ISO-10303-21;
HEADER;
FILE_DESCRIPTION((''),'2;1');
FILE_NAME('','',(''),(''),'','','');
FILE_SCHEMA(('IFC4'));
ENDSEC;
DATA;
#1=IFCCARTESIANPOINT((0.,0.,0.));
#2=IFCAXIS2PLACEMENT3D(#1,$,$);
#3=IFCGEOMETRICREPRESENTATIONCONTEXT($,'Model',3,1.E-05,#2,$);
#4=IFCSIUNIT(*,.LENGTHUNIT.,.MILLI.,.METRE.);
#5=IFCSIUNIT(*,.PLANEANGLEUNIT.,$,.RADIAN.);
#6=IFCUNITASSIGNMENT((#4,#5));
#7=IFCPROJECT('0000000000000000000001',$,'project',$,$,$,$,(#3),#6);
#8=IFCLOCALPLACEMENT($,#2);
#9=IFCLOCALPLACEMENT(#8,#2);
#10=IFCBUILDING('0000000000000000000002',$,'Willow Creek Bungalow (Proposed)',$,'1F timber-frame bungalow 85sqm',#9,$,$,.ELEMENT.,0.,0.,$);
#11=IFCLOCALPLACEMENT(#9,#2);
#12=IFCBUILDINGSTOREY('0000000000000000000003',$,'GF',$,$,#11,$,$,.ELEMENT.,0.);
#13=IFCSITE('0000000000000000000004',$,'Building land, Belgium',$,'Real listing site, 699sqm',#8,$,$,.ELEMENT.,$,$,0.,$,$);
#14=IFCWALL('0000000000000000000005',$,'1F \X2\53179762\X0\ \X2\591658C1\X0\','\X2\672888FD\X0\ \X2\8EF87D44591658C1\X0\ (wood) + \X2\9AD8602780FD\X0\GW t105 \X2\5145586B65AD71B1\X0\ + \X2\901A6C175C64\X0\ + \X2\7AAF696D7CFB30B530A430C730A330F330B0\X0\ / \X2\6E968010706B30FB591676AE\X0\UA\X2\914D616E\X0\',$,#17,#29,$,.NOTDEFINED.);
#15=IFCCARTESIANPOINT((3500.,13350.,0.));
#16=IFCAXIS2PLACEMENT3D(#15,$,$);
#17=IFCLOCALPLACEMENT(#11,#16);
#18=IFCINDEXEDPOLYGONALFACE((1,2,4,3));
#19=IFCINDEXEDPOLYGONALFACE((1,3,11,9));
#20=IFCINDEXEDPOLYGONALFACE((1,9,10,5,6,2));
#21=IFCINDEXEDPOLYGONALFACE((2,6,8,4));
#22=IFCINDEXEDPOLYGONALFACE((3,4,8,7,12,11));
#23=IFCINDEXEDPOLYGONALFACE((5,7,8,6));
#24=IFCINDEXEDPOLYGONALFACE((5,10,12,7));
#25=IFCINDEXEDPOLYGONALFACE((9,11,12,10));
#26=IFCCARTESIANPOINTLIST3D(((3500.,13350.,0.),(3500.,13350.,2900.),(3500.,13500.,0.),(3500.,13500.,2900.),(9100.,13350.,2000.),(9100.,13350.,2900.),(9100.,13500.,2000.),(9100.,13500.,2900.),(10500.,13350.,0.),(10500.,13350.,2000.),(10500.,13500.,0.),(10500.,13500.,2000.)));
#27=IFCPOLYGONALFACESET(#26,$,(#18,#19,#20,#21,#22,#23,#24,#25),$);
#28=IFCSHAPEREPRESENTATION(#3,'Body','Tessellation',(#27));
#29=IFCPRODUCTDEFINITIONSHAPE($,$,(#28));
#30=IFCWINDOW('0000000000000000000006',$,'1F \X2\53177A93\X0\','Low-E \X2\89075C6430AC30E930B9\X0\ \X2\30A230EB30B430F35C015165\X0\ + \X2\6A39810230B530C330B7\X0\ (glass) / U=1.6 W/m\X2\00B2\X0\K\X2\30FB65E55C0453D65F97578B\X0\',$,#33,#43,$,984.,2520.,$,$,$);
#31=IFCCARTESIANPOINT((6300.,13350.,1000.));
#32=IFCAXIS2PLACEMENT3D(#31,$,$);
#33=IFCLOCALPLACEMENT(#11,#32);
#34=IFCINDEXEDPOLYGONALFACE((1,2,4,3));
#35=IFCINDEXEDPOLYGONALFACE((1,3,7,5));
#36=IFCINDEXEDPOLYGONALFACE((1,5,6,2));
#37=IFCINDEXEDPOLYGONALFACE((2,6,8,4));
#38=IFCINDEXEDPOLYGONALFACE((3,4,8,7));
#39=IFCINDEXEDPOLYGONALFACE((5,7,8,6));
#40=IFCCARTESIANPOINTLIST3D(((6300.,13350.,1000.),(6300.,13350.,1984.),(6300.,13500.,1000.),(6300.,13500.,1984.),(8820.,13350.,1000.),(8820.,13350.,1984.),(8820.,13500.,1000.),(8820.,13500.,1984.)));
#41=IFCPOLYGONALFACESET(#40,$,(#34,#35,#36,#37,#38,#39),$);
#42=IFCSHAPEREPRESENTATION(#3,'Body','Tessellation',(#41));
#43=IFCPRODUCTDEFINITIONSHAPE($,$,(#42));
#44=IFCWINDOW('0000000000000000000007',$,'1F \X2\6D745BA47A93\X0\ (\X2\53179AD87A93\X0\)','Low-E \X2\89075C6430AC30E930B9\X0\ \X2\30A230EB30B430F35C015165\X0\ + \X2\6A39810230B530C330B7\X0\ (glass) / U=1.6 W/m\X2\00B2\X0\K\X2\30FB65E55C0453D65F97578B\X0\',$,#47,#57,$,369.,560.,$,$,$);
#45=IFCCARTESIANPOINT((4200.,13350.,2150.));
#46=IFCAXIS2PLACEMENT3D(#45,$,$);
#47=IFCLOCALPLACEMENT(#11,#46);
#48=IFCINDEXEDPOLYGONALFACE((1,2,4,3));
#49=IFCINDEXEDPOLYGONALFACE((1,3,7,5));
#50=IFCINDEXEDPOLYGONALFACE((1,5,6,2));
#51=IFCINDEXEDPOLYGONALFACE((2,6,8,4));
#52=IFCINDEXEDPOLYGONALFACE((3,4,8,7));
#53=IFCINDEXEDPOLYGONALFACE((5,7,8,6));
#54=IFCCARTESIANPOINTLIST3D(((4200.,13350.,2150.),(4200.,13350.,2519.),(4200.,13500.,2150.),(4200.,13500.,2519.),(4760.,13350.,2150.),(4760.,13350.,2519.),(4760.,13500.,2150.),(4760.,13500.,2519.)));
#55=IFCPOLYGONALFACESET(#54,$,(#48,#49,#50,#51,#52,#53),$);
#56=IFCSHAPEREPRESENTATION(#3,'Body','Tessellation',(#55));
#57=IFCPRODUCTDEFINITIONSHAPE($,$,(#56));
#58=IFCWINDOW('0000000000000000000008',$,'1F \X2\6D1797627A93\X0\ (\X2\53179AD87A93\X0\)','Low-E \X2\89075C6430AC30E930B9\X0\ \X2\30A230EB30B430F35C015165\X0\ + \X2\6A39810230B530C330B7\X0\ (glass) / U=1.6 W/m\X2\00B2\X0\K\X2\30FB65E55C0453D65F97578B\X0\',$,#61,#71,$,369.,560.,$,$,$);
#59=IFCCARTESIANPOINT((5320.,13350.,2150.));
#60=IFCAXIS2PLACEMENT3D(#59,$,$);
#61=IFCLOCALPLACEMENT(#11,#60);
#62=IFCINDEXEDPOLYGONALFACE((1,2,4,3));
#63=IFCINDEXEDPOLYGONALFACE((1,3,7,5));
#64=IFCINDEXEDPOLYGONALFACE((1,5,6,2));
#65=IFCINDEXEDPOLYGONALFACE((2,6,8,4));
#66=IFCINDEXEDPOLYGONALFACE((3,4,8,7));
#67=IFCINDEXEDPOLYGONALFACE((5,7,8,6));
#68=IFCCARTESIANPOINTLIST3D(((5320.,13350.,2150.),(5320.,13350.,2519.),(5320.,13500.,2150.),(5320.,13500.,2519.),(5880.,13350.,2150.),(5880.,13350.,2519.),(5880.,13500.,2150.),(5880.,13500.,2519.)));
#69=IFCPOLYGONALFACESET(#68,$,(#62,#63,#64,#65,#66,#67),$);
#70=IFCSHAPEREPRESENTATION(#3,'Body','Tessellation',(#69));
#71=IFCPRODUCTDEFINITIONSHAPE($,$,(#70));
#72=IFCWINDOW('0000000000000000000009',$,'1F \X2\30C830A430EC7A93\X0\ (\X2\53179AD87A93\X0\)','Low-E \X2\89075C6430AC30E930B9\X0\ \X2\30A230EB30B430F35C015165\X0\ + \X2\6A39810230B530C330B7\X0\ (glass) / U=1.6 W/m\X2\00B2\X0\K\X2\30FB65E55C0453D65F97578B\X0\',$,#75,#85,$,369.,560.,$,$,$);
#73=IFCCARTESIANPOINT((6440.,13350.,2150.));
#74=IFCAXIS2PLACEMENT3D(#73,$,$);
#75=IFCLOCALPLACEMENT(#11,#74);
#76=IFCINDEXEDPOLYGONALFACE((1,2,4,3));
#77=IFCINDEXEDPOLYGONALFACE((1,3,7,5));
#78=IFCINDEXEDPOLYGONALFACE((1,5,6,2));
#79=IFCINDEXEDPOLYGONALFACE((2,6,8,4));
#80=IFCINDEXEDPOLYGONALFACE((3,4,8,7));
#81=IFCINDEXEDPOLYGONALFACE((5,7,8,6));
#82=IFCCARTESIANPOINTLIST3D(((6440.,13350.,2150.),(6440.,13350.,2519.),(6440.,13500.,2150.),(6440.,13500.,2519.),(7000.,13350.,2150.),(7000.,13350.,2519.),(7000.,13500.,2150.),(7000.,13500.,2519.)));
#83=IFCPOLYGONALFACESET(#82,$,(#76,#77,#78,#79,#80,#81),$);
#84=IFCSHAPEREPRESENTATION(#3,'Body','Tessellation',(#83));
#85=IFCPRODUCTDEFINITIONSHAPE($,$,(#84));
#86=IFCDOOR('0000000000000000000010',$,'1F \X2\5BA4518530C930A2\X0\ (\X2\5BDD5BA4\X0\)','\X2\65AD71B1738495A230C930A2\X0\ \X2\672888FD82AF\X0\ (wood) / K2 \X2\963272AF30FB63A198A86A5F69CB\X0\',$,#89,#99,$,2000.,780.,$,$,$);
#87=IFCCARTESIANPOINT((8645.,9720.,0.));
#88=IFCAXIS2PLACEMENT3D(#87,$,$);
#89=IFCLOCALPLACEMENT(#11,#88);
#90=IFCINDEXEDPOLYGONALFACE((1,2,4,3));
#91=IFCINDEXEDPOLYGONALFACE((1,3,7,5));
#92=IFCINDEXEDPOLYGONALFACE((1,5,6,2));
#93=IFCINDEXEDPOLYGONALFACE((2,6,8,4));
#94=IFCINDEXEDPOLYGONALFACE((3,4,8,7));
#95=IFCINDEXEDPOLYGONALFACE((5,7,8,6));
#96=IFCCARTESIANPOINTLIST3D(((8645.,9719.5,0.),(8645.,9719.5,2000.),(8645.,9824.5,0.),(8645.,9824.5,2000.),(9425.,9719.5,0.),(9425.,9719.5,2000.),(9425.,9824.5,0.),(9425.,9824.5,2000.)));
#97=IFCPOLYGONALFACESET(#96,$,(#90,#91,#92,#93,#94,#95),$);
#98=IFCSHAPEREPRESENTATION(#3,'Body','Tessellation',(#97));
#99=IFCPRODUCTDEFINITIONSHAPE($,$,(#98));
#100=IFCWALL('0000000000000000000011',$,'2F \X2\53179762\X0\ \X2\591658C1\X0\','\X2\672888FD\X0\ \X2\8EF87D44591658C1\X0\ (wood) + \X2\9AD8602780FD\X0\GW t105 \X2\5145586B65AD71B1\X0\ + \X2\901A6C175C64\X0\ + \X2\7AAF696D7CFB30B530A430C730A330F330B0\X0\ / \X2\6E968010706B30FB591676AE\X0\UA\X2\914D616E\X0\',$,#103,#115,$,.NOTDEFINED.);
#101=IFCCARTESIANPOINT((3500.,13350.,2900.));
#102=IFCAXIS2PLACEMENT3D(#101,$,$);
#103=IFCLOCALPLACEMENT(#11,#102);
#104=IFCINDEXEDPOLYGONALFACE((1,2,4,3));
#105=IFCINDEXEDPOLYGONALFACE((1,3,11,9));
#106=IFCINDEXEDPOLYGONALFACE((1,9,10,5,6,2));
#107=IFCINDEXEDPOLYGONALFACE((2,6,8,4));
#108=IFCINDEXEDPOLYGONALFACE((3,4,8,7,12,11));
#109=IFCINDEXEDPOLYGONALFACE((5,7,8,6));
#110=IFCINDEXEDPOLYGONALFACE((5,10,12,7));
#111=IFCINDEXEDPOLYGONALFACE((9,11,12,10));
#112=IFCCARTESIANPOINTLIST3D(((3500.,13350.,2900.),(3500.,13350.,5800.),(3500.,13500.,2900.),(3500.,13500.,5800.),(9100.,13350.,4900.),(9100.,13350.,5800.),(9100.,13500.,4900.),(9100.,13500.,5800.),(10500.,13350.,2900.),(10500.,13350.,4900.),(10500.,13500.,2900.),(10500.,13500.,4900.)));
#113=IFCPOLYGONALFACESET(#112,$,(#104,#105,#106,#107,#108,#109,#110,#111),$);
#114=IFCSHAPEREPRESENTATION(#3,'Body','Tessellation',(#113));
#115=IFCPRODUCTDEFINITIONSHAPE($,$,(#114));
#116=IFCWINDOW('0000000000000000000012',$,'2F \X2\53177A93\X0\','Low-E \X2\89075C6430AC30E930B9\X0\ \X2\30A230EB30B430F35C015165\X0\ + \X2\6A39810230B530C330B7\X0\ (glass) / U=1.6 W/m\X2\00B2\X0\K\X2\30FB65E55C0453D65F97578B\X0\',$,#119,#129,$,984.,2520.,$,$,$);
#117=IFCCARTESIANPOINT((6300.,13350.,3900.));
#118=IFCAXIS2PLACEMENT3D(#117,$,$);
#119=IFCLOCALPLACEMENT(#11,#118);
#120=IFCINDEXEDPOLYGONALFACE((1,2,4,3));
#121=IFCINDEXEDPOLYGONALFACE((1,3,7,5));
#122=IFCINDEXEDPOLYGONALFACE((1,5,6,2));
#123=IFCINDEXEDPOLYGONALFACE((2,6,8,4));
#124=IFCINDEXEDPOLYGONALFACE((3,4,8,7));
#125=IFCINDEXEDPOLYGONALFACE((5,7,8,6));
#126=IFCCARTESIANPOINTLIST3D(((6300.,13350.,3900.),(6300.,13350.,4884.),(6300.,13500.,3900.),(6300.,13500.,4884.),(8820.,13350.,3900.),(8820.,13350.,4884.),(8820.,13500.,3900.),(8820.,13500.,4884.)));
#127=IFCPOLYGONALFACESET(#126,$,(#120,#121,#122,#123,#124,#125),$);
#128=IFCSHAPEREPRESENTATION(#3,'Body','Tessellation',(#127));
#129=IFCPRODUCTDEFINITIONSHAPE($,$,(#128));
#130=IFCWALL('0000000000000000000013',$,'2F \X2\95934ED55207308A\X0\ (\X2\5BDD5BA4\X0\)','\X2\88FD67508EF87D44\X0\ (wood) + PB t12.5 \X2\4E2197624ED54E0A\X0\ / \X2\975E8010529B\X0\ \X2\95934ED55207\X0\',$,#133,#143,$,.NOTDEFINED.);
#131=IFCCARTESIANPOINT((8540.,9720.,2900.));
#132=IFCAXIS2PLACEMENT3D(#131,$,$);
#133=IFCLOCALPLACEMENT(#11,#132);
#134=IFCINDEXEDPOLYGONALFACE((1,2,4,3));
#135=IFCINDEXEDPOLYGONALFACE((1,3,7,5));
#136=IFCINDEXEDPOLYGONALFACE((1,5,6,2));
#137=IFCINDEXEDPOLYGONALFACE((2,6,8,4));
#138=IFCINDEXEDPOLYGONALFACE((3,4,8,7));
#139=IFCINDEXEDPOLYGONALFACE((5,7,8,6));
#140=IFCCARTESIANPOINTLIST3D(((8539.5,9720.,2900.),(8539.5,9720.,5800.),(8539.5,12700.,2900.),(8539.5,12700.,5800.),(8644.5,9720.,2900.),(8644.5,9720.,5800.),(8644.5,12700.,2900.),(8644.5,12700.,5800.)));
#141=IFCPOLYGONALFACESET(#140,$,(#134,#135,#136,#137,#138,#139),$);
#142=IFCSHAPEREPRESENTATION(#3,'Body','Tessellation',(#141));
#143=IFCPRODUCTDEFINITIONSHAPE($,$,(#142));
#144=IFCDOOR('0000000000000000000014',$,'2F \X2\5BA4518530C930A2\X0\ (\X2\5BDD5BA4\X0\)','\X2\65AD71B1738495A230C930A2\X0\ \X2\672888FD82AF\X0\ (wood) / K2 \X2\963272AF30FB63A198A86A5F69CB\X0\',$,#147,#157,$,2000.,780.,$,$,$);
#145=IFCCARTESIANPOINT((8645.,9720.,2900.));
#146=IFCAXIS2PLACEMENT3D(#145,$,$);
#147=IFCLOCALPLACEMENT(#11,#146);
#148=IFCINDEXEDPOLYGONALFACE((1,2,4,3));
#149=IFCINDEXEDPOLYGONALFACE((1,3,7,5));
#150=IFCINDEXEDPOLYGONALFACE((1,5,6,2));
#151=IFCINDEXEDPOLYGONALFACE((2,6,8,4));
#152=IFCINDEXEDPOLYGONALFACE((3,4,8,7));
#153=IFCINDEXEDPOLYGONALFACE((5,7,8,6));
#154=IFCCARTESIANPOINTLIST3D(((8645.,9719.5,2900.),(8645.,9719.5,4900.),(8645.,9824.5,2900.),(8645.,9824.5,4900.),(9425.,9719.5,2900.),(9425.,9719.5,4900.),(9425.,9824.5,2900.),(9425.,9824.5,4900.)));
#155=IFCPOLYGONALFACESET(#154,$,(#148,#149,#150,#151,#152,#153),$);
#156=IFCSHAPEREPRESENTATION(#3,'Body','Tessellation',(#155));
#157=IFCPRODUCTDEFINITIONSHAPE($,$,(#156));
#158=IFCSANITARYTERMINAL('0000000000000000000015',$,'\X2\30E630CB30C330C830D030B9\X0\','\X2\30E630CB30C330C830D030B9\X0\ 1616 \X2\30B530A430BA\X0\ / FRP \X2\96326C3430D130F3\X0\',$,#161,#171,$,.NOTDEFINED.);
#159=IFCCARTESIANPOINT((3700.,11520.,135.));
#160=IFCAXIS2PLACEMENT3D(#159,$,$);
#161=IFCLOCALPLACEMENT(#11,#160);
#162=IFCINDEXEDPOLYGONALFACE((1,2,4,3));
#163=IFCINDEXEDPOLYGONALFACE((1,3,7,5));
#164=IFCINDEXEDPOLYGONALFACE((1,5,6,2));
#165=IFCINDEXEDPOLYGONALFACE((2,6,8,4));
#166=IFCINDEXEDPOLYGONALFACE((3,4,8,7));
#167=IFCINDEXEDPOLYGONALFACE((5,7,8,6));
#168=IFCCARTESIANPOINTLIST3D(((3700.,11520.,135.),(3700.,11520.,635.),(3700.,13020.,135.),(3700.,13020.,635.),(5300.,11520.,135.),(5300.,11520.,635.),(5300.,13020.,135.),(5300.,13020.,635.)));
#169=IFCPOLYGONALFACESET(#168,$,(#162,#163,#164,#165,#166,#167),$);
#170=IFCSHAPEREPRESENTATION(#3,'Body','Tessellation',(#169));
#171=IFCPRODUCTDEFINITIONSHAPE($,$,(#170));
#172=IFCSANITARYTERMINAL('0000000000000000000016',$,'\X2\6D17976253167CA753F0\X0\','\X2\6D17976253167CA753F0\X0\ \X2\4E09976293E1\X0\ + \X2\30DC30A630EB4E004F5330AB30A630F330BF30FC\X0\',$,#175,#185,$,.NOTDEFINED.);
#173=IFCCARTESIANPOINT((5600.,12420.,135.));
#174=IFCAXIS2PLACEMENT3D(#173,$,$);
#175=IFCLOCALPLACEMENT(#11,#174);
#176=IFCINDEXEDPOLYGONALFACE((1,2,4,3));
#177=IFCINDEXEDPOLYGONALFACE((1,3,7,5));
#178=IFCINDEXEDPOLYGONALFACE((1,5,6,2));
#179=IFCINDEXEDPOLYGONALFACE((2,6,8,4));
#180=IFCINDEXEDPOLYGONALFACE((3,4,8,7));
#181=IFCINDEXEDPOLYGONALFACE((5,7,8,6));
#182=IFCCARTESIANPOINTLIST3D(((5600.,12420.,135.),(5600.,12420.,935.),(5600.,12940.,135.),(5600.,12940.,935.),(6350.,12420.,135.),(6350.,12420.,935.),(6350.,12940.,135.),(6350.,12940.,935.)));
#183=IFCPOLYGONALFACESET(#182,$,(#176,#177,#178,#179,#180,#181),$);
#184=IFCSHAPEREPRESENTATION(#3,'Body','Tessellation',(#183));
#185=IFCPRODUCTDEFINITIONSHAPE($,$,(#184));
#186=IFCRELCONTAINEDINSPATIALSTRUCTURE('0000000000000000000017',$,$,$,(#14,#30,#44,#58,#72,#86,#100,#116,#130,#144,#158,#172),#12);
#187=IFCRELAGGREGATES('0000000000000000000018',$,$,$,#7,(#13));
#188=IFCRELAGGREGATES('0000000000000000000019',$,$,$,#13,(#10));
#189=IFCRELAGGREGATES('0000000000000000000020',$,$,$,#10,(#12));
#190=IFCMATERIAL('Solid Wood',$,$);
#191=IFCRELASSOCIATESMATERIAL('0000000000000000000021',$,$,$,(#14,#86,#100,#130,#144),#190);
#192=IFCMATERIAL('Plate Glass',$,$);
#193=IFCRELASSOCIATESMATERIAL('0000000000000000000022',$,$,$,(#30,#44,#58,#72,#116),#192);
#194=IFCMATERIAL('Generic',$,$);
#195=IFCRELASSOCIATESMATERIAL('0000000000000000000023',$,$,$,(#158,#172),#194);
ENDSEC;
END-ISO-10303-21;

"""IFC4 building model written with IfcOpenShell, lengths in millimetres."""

from ifc_helpers import new_model, si_unit, frame, frame_2d, origin, place, context, project, spatial, rectangle, extrude, material, element, fill, save


model = new_model("IFC4")

# Units and contexts
model_context = context("Model", 3, precision=1e-05, world=origin())
ifc_project = project(units=[si_unit("LENGTHUNIT", "METRE", prefix="MILLI"), si_unit("PLANEANGLEUNIT", "RADIAN")], contexts=[model_context])

# Site, building, storey
site_placement = place(None, origin())
site = spatial("IfcSite", under=ifc_project, at=site_placement, Name="Building land, Belgium", ObjectType="Real listing site, 699sqm", CompositionType="ELEMENT", RefElevation=0.0)
building_placement = place(site_placement, origin())
building = spatial("IfcBuilding", under=site, at=building_placement, Name="Willow Creek Bungalow (Proposed)", ObjectType="1F timber-frame bungalow 85sqm", CompositionType="ELEMENT", ElevationOfRefHeight=0.0, ElevationOfTerrain=0.0)
storey_placement = place(building_placement, origin())
storey = spatial("IfcBuildingStorey", under=building, at=storey_placement, Name="GF", CompositionType="ELEMENT", Elevation=0.0)

# Wall, openings, windows
ifc_material_1 = material(Name="Solid Wood")
wall_1_placement = place(storey_placement, frame((3500.0, 13350.0, 0.0)))
wall_1 = element("IfcWall", 1, at=wall_1_placement, inside=storey, material=ifc_material_1, Name="1F 北面 外壁", Description="木製 軸組外壁 (wood) + 高性能GW t105 充填断熱 + 通気層 + 窯業系サイディング / 準耐火・外皮UA配慮", PredefinedType="NOTDEFINED", context=model_context, shape_type="SweptSolid", body=[
    extrude(rectangle(XDim=7000.0, YDim=150.0, at=frame_2d((3500.0, 75.0))), frame((3500.0, 13350.0, 0.0)), (0.0, 0.0, 1.0), 2900.0),
])
opening_1_placement = place(storey_placement, frame((6300.0, 13350.0, 1000.0)))
opening_1 = element("IfcOpeningElement", 2, at=opening_1_placement, cuts=wall_1, PredefinedType="NOTDEFINED", context=model_context, shape_type="SweptSolid", body=[
    extrude(rectangle(XDim=2520.0, YDim=150.0, at=frame_2d((1260.0, 75.0))), frame((6300.0, 13350.0, 1000.0)), (0.0, 0.0, 1.0), 984.0),
])
opening_2_placement = place(storey_placement, frame((4200.0, 13350.0, 2150.0)))
opening_2 = element("IfcOpeningElement", 3, at=opening_2_placement, cuts=wall_1, PredefinedType="NOTDEFINED", context=model_context, shape_type="SweptSolid", body=[
    extrude(rectangle(XDim=560.0, YDim=150.0, at=frame_2d((280.0, 75.0))), frame((4200.0, 13350.0, 2150.0)), (0.0, 0.0, 1.0), 369.0),
])
opening_3_placement = place(storey_placement, frame((5320.0, 13350.0, 2150.0)))
opening_3 = element("IfcOpeningElement", 4, at=opening_3_placement, cuts=wall_1, PredefinedType="NOTDEFINED", context=model_context, shape_type="SweptSolid", body=[
    extrude(rectangle(XDim=560.0, YDim=150.0, at=frame_2d((280.0, 75.0))), frame((5320.0, 13350.0, 2150.0)), (0.0, 0.0, 1.0), 369.0),
])
opening_4_placement = place(storey_placement, frame((6440.0, 13350.0, 2150.0)))
opening_4 = element("IfcOpeningElement", 5, at=opening_4_placement, cuts=wall_1, PredefinedType="NOTDEFINED", context=model_context, shape_type="SweptSolid", body=[
    extrude(rectangle(XDim=560.0, YDim=150.0, at=frame_2d((280.0, 75.0))), frame((6440.0, 13350.0, 2150.0)), (0.0, 0.0, 1.0), 369.0),
])
ifc_material_2 = material(Name="Plate Glass")
window_1_placement = place(storey_placement, frame((6300.0, 13350.0, 1000.0)))
window_1 = element("IfcWindow", 6, at=window_1_placement, inside=storey, material=ifc_material_2, Name="1F 北窓", Description="Low-E 複層ガラス アルゴン封入 + 樹脂サッシ (glass) / U=1.6 W/m²K・日射取得型", OverallHeight=984.0, OverallWidth=2520.0, context=model_context, shape_type="SweptSolid", body=[
    extrude(rectangle(XDim=2520.0, YDim=150.0, at=frame_2d((1260.0, 75.0))), frame((6300.0, 13350.0, 1000.0)), (0.0, 0.0, 1.0), 984.0),
])
fill(opening_1, window_1)
window_2_placement = place(storey_placement, frame((4200.0, 13350.0, 2150.0)))
window_2 = element("IfcWindow", 7, at=window_2_placement, inside=storey, material=ifc_material_2, Name="1F 浴室窓 (北高窓)", Description="Low-E 複層ガラス アルゴン封入 + 樹脂サッシ (glass) / U=1.6 W/m²K・日射取得型", OverallHeight=369.0, OverallWidth=560.0, context=model_context, shape_type="SweptSolid", body=[
    extrude(rectangle(XDim=560.0, YDim=150.0, at=frame_2d((280.0, 75.0))), frame((4200.0, 13350.0, 2150.0)), (0.0, 0.0, 1.0), 369.0),
])
fill(opening_2, window_2)
window_3_placement = place(storey_placement, frame((5320.0, 13350.0, 2150.0)))
window_3 = element("IfcWindow", 8, at=window_3_placement, inside=storey, material=ifc_material_2, Name="1F 洗面窓 (北高窓)", Description="Low-E 複層ガラス アルゴン封入 + 樹脂サッシ (glass) / U=1.6 W/m²K・日射取得型", OverallHeight=369.0, OverallWidth=560.0, context=model_context, shape_type="SweptSolid", body=[
    extrude(rectangle(XDim=560.0, YDim=150.0, at=frame_2d((280.0, 75.0))), frame((5320.0, 13350.0, 2150.0)), (0.0, 0.0, 1.0), 369.0),
])
fill(opening_3, window_3)
window_4_placement = place(storey_placement, frame((6440.0, 13350.0, 2150.0)))
window_4 = element("IfcWindow", 9, at=window_4_placement, inside=storey, material=ifc_material_2, Name="1F トイレ窓 (北高窓)", Description="Low-E 複層ガラス アルゴン封入 + 樹脂サッシ (glass) / U=1.6 W/m²K・日射取得型", OverallHeight=369.0, OverallWidth=560.0, context=model_context, shape_type="SweptSolid", body=[
    extrude(rectangle(XDim=560.0, YDim=150.0, at=frame_2d((280.0, 75.0))), frame((6440.0, 13350.0, 2150.0)), (0.0, 0.0, 1.0), 369.0),
])
fill(opening_4, window_4)

# Door
door_1_placement = place(storey_placement, frame((8645.0, 9720.0, 0.0)))
element("IfcDoor", 10, at=door_1_placement, inside=storey, material=ifc_material_1, Name="1F 室内ドア (寝室)", Description="断熱玄関ドア 木製芯 (wood) / K2 防犯・採風機構", OverallHeight=2000.0, OverallWidth=780.0, context=model_context, shape_type="SweptSolid", body=[
    extrude(rectangle(XDim=780.0, YDim=105.0, at=frame_2d((390.0, 52.0))), frame((8645.0, 9720.0, 0.0)), (0.0, 0.0, 1.0), 2000.0),
])

# Wall, opening, window
wall_2_placement = place(storey_placement, frame((3500.0, 13350.0, 2900.0)))
wall_2 = element("IfcWall", 11, at=wall_2_placement, inside=storey, material=ifc_material_1, Name="2F 北面 外壁", Description="木製 軸組外壁 (wood) + 高性能GW t105 充填断熱 + 通気層 + 窯業系サイディング / 準耐火・外皮UA配慮", PredefinedType="NOTDEFINED", context=model_context, shape_type="SweptSolid", body=[
    extrude(rectangle(XDim=7000.0, YDim=150.0, at=frame_2d((3500.0, 75.0))), frame((3500.0, 13350.0, 2900.0)), (0.0, 0.0, 1.0), 2900.0),
])
opening_5_placement = place(storey_placement, frame((6300.0, 13350.0, 3900.0)))
opening_5 = element("IfcOpeningElement", 12, at=opening_5_placement, cuts=wall_2, PredefinedType="NOTDEFINED", context=model_context, shape_type="SweptSolid", body=[
    extrude(rectangle(XDim=2520.0, YDim=150.0, at=frame_2d((1260.0, 75.0))), frame((6300.0, 13350.0, 3900.0)), (0.0, 0.0, 1.0), 984.0),
])
window_5_placement = place(storey_placement, frame((6300.0, 13350.0, 3900.0)))
window_5 = element("IfcWindow", 13, at=window_5_placement, inside=storey, material=ifc_material_2, Name="2F 北窓", Description="Low-E 複層ガラス アルゴン封入 + 樹脂サッシ (glass) / U=1.6 W/m²K・日射取得型", OverallHeight=984.0, OverallWidth=2520.0, context=model_context, shape_type="SweptSolid", body=[
    extrude(rectangle(XDim=2520.0, YDim=150.0, at=frame_2d((1260.0, 75.0))), frame((6300.0, 13350.0, 3900.0)), (0.0, 0.0, 1.0), 984.0),
])
fill(opening_5, window_5)

# Wall
wall_3_placement = place(storey_placement, frame((8540.0, 9720.0, 2900.0)))
element("IfcWall", 14, at=wall_3_placement, inside=storey, material=ifc_material_1, Name="2F 間仕切り (寝室)", Description="製材軸組 (wood) + PB t12.5 両面仕上 / 非耐力 間仕切", PredefinedType="NOTDEFINED", context=model_context, shape_type="SweptSolid", body=[
    extrude(rectangle(XDim=105.0, YDim=2980.0, at=frame_2d((52.0, 1490.0))), frame((8540.0, 9720.0, 2900.0)), (0.0, 0.0, 1.0), 2900.0),
])

# Door
door_2_placement = place(storey_placement, frame((8645.0, 9720.0, 2900.0)))
element("IfcDoor", 15, at=door_2_placement, inside=storey, material=ifc_material_1, Name="2F 室内ドア (寝室)", Description="断熱玄関ドア 木製芯 (wood) / K2 防犯・採風機構", OverallHeight=2000.0, OverallWidth=780.0, context=model_context, shape_type="SweptSolid", body=[
    extrude(rectangle(XDim=780.0, YDim=105.0, at=frame_2d((390.0, 52.0))), frame((8645.0, 9720.0, 2900.0)), (0.0, 0.0, 1.0), 2000.0),
])

# Sanitary terminals
ifc_material_3 = material(Name="Generic")
sanitary_terminal_1_placement = place(storey_placement, frame((3700.0, 11520.0, 135.0)))
element("IfcSanitaryTerminal", 16, at=sanitary_terminal_1_placement, inside=storey, material=ifc_material_3, Name="ユニットバス", Description="ユニットバス 1616 サイズ / FRP 防水パン", PredefinedType="NOTDEFINED", context=model_context, shape_type="SweptSolid", body=[
    extrude(rectangle(XDim=1600.0, YDim=1500.0, at=frame_2d((800.0, 750.0))), frame((3700.0, 11520.0, 135.0)), (0.0, 0.0, 1.0), 500.0),
])
sanitary_terminal_2_placement = place(storey_placement, frame((5600.0, 12420.0, 135.0)))
element("IfcSanitaryTerminal", 17, at=sanitary_terminal_2_placement, inside=storey, material=ifc_material_3, Name="洗面化粧台", Description="洗面化粧台 三面鏡 + ボウル一体カウンター", PredefinedType="NOTDEFINED", context=model_context, shape_type="SweptSolid", body=[
    extrude(rectangle(XDim=750.0, YDim=520.0, at=frame_2d((375.0, 260.0))), frame((5600.0, 12420.0, 135.0)), (0.0, 0.0, 1.0), 800.0),
])

save(model, "model.ifc")
